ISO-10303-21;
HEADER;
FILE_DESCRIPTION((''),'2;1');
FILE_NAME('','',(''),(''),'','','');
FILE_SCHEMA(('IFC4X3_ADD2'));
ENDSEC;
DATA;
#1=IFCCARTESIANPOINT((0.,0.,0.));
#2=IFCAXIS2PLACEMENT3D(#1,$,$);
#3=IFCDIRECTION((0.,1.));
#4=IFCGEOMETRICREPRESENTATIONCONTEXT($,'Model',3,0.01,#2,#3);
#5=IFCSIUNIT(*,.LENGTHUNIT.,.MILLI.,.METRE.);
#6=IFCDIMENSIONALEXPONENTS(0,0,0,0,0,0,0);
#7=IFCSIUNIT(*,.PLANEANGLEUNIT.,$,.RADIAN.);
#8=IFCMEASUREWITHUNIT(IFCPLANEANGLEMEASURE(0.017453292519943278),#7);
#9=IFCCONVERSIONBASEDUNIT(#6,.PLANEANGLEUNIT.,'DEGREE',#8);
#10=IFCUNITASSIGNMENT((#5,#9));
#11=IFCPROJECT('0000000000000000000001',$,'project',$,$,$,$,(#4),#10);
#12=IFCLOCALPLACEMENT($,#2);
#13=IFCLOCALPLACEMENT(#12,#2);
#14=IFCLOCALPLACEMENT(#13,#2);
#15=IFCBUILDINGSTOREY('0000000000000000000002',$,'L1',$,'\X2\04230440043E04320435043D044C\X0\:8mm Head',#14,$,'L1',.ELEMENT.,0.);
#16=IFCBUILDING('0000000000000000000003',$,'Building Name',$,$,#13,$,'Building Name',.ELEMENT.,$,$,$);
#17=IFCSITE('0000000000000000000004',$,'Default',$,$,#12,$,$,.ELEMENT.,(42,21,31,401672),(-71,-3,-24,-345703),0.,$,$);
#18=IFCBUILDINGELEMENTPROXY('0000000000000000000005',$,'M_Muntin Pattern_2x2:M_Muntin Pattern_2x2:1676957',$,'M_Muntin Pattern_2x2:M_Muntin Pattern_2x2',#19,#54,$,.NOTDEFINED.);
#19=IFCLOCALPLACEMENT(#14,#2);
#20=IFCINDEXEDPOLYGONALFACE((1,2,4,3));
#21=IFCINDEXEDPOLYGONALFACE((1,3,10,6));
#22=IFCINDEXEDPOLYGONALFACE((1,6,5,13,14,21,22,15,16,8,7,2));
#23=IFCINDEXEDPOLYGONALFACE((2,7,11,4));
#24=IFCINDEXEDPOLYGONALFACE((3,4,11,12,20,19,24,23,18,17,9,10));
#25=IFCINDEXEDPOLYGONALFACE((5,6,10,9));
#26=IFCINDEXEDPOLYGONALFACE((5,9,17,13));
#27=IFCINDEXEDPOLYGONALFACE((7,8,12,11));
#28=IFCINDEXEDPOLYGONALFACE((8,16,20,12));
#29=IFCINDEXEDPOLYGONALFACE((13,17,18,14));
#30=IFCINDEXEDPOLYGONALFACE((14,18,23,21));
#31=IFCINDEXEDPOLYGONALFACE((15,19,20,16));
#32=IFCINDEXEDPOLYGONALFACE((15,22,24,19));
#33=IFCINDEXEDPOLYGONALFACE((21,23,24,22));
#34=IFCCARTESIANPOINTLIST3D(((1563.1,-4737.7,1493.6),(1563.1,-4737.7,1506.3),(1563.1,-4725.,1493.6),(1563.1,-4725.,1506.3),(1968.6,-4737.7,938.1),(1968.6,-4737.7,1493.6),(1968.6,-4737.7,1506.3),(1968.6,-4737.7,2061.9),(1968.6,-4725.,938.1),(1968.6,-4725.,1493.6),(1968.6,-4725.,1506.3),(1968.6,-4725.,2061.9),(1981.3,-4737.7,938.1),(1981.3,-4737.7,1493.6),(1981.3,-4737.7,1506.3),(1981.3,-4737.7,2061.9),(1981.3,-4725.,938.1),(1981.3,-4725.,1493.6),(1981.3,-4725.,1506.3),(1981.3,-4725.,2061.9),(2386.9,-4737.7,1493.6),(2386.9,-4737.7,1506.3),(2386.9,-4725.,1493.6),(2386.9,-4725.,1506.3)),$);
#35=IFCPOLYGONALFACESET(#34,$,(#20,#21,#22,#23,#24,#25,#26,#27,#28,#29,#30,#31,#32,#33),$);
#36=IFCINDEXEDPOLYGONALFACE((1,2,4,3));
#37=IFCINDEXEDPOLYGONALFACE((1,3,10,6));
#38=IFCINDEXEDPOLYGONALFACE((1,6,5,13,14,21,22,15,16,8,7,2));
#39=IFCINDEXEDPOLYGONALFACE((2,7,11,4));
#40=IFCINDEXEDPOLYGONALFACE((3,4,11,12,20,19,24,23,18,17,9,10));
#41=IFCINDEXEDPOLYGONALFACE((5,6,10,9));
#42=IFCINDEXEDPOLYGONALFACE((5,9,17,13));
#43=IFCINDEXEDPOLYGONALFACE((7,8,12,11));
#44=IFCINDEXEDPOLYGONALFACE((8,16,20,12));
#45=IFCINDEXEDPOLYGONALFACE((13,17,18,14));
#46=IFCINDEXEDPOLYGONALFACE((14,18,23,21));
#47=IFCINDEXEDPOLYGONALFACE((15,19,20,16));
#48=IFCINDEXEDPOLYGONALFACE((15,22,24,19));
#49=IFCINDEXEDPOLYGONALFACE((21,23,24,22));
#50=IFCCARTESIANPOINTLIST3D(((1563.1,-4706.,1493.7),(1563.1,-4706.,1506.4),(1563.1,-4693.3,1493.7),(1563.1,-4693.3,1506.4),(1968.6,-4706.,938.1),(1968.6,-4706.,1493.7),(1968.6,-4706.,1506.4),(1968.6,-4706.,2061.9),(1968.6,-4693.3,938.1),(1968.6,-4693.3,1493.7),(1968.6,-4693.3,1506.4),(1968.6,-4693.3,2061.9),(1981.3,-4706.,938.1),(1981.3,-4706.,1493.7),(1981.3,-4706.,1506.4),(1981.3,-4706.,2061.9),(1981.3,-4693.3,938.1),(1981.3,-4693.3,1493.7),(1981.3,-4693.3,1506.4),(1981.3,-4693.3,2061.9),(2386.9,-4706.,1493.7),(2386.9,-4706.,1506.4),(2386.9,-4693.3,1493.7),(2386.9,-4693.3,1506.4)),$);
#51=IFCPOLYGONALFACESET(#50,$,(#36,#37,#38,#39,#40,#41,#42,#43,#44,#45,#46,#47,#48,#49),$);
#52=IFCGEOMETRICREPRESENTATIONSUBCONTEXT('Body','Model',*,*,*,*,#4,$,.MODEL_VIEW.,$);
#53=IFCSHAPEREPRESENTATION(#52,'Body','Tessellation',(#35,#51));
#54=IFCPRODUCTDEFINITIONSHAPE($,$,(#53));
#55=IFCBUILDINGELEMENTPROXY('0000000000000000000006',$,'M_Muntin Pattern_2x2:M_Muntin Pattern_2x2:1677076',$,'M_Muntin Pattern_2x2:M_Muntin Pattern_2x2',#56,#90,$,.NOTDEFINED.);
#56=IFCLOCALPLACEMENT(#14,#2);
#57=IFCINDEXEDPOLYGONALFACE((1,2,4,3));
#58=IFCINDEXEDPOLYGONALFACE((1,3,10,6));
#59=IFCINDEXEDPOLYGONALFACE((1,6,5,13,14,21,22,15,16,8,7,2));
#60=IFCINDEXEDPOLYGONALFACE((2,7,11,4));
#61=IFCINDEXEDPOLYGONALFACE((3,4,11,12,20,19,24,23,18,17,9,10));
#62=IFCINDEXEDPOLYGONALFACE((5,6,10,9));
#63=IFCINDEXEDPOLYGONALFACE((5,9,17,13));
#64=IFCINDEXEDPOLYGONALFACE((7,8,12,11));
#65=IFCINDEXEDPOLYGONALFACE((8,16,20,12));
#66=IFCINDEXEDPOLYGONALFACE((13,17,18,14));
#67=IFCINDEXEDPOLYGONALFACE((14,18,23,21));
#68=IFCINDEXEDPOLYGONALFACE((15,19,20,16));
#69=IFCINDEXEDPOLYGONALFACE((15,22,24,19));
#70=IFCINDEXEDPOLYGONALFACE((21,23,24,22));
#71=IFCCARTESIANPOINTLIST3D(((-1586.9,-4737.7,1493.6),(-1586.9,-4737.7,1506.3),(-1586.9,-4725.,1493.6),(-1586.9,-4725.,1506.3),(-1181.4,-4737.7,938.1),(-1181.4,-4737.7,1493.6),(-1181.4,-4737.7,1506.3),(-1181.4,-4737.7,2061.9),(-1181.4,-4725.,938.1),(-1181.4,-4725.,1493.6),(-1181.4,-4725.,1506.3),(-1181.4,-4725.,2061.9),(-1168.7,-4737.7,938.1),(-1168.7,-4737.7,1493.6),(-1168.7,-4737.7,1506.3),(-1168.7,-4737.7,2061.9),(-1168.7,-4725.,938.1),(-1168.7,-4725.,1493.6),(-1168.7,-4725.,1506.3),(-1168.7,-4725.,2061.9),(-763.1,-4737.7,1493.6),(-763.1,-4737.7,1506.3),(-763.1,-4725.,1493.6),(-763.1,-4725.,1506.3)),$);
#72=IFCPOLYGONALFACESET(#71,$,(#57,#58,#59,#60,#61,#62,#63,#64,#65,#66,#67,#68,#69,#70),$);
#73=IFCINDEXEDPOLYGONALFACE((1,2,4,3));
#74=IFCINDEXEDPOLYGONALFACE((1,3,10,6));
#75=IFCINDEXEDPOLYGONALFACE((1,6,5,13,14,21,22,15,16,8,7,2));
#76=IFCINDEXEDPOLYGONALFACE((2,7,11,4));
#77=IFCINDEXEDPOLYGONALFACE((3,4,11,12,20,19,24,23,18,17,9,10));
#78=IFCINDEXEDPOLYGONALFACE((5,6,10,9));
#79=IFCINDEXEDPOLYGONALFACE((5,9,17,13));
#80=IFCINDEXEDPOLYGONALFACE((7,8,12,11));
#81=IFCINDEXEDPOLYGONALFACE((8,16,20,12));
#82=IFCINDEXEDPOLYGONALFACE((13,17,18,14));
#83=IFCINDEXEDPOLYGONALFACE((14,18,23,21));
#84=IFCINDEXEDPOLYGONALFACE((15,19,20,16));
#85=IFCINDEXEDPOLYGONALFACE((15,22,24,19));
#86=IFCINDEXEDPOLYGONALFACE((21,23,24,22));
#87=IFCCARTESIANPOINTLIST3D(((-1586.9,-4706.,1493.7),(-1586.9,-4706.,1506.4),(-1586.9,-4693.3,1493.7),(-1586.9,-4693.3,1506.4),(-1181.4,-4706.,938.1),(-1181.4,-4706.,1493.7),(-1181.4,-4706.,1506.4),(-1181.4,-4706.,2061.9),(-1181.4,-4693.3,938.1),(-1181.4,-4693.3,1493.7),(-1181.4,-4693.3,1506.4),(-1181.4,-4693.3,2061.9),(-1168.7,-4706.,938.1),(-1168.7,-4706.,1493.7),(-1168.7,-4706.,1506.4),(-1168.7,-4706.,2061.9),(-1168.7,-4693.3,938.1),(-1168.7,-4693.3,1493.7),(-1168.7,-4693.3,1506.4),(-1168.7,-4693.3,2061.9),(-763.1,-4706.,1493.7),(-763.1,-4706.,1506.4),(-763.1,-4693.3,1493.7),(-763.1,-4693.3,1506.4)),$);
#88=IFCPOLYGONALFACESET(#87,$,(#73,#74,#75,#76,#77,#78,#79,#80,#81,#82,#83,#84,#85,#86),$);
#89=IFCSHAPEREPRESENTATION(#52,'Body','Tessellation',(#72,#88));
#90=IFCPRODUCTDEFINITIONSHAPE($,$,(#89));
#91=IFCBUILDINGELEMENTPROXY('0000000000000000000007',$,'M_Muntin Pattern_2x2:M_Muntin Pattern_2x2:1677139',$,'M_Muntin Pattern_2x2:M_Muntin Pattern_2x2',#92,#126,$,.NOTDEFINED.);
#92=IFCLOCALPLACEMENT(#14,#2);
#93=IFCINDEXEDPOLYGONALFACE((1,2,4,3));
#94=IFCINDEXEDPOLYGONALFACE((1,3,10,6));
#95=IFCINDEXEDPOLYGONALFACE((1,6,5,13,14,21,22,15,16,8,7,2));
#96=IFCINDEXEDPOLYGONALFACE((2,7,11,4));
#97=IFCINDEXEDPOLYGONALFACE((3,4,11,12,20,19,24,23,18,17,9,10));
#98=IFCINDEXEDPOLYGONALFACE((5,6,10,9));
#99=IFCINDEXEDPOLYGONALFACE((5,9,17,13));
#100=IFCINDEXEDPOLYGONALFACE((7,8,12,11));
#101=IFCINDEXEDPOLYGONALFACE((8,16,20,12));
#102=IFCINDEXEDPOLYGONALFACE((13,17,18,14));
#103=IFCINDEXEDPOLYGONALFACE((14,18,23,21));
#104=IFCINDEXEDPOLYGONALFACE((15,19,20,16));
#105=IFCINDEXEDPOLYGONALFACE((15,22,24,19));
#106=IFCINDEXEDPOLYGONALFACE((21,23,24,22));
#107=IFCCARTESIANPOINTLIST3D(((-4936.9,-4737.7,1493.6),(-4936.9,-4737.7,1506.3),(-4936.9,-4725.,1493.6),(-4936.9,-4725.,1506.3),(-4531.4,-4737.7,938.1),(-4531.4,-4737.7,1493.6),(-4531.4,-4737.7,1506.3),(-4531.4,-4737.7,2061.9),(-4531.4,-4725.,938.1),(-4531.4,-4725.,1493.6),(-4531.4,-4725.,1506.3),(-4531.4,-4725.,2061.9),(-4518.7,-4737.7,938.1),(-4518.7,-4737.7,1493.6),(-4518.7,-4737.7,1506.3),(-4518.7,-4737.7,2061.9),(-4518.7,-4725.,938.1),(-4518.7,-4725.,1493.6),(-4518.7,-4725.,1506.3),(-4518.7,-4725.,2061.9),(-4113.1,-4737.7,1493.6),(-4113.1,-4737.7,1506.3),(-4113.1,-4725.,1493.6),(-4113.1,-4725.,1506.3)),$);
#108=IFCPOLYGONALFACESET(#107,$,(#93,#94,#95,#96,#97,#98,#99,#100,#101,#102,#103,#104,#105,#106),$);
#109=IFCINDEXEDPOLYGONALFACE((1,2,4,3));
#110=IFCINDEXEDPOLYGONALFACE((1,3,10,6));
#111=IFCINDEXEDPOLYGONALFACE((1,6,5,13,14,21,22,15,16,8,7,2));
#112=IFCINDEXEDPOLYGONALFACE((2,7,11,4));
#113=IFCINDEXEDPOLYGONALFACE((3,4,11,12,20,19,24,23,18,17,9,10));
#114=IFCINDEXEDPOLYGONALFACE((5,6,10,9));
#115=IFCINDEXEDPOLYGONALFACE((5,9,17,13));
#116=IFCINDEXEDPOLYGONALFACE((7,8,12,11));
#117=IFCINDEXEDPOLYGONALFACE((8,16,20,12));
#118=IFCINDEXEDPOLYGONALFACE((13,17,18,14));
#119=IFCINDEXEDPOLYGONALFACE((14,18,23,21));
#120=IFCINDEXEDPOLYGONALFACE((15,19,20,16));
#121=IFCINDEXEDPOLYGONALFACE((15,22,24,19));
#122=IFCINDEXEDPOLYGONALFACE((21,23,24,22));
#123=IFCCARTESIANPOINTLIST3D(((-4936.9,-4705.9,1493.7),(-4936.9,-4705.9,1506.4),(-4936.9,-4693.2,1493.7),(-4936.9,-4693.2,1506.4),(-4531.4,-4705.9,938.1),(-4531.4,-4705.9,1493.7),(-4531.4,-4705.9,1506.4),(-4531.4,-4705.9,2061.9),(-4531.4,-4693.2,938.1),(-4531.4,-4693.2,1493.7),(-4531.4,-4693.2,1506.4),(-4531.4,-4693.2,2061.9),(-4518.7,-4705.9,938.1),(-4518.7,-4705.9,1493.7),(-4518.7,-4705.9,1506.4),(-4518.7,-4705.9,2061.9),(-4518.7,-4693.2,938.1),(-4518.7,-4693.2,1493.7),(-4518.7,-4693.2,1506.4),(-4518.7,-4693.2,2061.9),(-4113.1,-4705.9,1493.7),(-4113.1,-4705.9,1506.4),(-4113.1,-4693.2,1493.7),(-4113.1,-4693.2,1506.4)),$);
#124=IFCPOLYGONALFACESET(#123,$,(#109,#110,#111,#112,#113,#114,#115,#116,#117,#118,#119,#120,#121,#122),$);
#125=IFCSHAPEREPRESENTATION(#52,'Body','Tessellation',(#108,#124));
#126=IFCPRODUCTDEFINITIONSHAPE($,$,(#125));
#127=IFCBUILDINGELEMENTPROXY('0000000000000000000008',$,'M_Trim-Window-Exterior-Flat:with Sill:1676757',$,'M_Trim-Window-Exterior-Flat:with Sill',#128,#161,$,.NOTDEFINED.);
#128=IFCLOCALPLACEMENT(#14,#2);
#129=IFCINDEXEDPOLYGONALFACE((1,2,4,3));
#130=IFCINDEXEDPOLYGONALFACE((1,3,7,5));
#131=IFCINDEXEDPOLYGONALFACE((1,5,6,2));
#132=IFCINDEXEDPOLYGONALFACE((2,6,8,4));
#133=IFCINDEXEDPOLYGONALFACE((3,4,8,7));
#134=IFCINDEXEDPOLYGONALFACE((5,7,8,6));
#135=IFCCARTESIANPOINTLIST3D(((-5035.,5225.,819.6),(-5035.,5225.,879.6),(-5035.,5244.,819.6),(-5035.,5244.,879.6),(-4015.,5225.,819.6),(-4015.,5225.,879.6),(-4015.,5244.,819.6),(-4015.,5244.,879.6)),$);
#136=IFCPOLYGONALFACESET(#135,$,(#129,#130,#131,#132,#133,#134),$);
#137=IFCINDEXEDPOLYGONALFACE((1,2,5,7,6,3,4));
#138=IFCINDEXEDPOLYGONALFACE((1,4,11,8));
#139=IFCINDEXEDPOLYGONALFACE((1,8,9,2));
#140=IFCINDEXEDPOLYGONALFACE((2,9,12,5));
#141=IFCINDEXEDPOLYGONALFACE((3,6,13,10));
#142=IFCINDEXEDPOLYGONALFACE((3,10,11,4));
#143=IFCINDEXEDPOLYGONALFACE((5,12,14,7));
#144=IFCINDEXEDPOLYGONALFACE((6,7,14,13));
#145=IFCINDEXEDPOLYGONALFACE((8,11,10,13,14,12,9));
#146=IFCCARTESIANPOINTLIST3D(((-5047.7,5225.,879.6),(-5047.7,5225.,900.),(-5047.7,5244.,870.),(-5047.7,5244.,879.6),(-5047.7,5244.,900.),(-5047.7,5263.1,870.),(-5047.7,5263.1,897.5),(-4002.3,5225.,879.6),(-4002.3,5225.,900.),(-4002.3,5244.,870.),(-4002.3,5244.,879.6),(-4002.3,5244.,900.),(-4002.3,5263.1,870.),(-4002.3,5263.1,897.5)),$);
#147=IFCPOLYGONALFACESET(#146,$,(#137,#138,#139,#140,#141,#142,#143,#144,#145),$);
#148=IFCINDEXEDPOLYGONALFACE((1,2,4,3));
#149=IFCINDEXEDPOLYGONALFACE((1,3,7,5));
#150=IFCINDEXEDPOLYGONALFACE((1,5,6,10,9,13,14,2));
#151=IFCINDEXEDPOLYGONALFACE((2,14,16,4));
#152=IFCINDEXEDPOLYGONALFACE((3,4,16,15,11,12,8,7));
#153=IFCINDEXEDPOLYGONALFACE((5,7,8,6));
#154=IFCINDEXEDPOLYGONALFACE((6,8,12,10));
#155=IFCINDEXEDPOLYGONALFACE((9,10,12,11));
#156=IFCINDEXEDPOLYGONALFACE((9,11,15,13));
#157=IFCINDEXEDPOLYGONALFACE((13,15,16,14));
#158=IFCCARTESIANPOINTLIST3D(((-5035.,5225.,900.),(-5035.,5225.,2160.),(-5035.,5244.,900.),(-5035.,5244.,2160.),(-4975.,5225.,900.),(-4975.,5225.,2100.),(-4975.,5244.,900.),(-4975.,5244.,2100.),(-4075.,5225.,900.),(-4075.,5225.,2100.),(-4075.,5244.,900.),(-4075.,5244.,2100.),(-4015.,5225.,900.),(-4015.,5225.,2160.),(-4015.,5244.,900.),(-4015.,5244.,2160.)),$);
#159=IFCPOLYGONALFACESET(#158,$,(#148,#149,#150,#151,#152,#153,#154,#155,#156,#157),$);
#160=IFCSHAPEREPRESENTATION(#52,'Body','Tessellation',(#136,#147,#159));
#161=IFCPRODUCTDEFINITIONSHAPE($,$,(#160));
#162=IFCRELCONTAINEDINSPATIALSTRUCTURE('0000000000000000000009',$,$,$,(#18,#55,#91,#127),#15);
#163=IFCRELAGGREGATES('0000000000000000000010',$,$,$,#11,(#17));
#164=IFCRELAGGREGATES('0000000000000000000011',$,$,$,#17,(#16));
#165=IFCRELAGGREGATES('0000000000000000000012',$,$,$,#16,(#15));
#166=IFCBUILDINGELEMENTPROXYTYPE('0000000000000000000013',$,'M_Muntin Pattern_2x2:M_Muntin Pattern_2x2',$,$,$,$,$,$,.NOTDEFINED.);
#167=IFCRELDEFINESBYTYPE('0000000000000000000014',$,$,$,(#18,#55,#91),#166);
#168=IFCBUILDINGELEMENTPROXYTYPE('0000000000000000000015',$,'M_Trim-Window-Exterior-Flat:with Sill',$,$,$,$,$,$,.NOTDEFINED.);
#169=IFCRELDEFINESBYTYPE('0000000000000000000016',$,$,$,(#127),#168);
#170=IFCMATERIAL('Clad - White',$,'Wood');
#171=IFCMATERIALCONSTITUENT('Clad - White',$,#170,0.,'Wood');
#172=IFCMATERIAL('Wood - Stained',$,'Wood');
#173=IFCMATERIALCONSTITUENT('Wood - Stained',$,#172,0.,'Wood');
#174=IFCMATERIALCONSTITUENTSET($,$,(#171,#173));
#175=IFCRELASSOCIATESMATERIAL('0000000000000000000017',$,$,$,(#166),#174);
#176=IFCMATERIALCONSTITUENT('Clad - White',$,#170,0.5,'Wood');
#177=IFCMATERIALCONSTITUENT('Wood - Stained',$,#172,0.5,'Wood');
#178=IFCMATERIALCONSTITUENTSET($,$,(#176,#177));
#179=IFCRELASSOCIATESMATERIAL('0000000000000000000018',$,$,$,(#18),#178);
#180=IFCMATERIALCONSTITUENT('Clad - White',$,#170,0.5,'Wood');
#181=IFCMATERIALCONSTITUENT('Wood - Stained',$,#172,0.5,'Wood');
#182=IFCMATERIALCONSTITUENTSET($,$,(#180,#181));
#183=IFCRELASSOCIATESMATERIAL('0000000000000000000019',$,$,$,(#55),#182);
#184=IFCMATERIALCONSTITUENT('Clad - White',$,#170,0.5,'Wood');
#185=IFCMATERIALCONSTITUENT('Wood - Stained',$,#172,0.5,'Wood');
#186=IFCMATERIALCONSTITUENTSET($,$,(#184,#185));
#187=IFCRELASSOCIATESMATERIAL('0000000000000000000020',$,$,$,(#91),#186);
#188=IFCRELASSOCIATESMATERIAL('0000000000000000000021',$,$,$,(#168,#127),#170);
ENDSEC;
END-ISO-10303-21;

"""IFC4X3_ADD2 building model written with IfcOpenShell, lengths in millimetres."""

from ifc_helpers import new_model, entity, si_unit, converted_unit, direction, frame, frame_2d, origin, place, context, subcontext, project, spatial, polyline, rectangle, outline, extrude, source, transform, mapped, material, constituent, constituent_set, type_object, type_shapes, element, save


model = new_model("IFC4X3_ADD2")

# Units and contexts
model_context = context("Model", 3, precision=0.01, world=origin(), true_north=direction((0.0, 1.0)))
body_context = subcontext(model_context, "Body", "Model", "MODEL_VIEW")
ifc_project = project(units=[si_unit("LENGTHUNIT", "METRE", prefix="MILLI"), converted_unit("PLANEANGLEUNIT", "DEGREE", entity("IfcPlaneAngleMeasure", 0.017453292519943278), si_unit("PLANEANGLEUNIT", "RADIAN"), dimensions=[0, 0, 0, 0, 0, 0, 0])], contexts=[model_context])

# Site, building, storey
site_placement = place(None, origin())
site = spatial("IfcSite", under=ifc_project, at=site_placement, Name="Default", CompositionType="ELEMENT", RefLatitude=(42, 21, 31, 401672), RefLongitude=(-71, -3, -24, -345703), RefElevation=0.0)
building_placement = place(site_placement, origin())
building = spatial("IfcBuilding", under=site, at=building_placement, Name="Building Name", LongName="Building Name", CompositionType="ELEMENT")
storey_placement = place(building_placement, origin())
storey = spatial("IfcBuildingStorey", under=building, at=storey_placement, Name="L1", ObjectType="Уровень:8mm Head", LongName="L1", CompositionType="ELEMENT", Elevation=0.0)

# Building element proxies
ifc_material_1 = material(Name="Clad - White", Category="Wood")
ifc_material_2 = material(Name="Wood - Stained", Category="Wood")
ifc_constituent_1 = constituent(ifc_material_1, Name="Clad - White", Category="Wood", fraction=0.0)
ifc_constituent_2 = constituent(ifc_material_2, Name="Wood - Stained", Category="Wood", fraction=0.0)
ifc_constituent_set_1 = constituent_set(constituents=[ifc_constituent_1, ifc_constituent_2])
building_element_proxy_type_1 = type_object("IfcBuildingElementProxyType", Name="M_Muntin Pattern_2x2:M_Muntin Pattern_2x2", PredefinedType="NOTDEFINED", material=ifc_constituent_set_1)
shared_shape_1 = source(origin(), body_context, "Body", "SweptSolid", [
    extrude(outline(polyline([(6.4, -6.4), (561.9, -6.4), (561.9, 6.3), (6.4, 6.3), (6.4, 411.9), (-6.3, 411.9), (-6.3, 6.3), (-561.9, 6.3), (-561.9, -6.4), (-6.3, -6.4), (-6.3, -411.9), (6.4, -411.9), (6.4, -6.4)])), frame((0.0, -22.2, 561.9), z_axis=(0.0, 1.0, 0.0), x_axis=(0.0, 0.0, 1.0)), (0.0, 0.0, 1.0), 12.7),
    extrude(outline(polyline([(6.4, -6.4), (561.9, -6.4), (561.9, 6.3), (6.4, 6.3), (6.4, 411.9), (-6.3, 411.9), (-6.3, 6.3), (-561.9, 6.3), (-561.9, -6.4), (-6.3, -6.4), (-6.3, -411.9), (6.4, -411.9), (6.4, -6.4)])), frame((0.0, 9.5, 561.9), z_axis=(0.0, 1.0, 0.0), x_axis=(0.0, 0.0, 1.0)), (0.0, 0.0, 1.0), 12.7),
])
type_shapes(building_element_proxy_type_1, [shared_shape_1])
ifc_constituent_3 = constituent(ifc_material_1, Name="Clad - White", Category="Wood", fraction=0.5)
ifc_constituent_4 = constituent(ifc_material_2, Name="Wood - Stained", Category="Wood", fraction=0.5)
ifc_constituent_set_2 = constituent_set(constituents=[ifc_constituent_3, ifc_constituent_4])
proxy_1_placement = place(storey_placement, frame((1975.0, -4715.5, 938.1)))
element("IfcBuildingElementProxy", 1, at=proxy_1_placement, inside=storey, type_object=building_element_proxy_type_1, material=ifc_constituent_set_2, Name="M_Muntin Pattern_2x2:M_Muntin Pattern_2x2:1676957", ObjectType="M_Muntin Pattern_2x2:M_Muntin Pattern_2x2", PredefinedType="NOTDEFINED", context=body_context, shape_type="MappedRepresentation", body=[
    mapped(shared_shape_1, transform((0.0, 0.0, 0.0), scale=1.0)),
])
ifc_constituent_5 = constituent(ifc_material_1, Name="Clad - White", Category="Wood", fraction=0.5)
ifc_constituent_6 = constituent(ifc_material_2, Name="Wood - Stained", Category="Wood", fraction=0.5)
ifc_constituent_set_3 = constituent_set(constituents=[ifc_constituent_5, ifc_constituent_6])
proxy_2_placement = place(storey_placement, frame((-1175.0, -4715.5, 938.1)))
element("IfcBuildingElementProxy", 2, at=proxy_2_placement, inside=storey, type_object=building_element_proxy_type_1, material=ifc_constituent_set_3, Name="M_Muntin Pattern_2x2:M_Muntin Pattern_2x2:1677076", ObjectType="M_Muntin Pattern_2x2:M_Muntin Pattern_2x2", PredefinedType="NOTDEFINED", context=body_context, shape_type="MappedRepresentation", body=[
    mapped(shared_shape_1, transform((0.0, 0.0, 0.0), scale=1.0)),
])
ifc_constituent_7 = constituent(ifc_material_1, Name="Clad - White", Category="Wood", fraction=0.5)
ifc_constituent_8 = constituent(ifc_material_2, Name="Wood - Stained", Category="Wood", fraction=0.5)
ifc_constituent_set_4 = constituent_set(constituents=[ifc_constituent_7, ifc_constituent_8])
proxy_3_placement = place(storey_placement, frame((-4525.0, -4715.5, 938.1)))
element("IfcBuildingElementProxy", 3, at=proxy_3_placement, inside=storey, type_object=building_element_proxy_type_1, material=ifc_constituent_set_4, Name="M_Muntin Pattern_2x2:M_Muntin Pattern_2x2:1677139", ObjectType="M_Muntin Pattern_2x2:M_Muntin Pattern_2x2", PredefinedType="NOTDEFINED", context=body_context, shape_type="MappedRepresentation", body=[
    mapped(shared_shape_1, transform((0.0, 0.0, 0.0), scale=1.0)),
])
building_element_proxy_type_2 = type_object("IfcBuildingElementProxyType", Name="M_Trim-Window-Exterior-Flat:with Sill", PredefinedType="NOTDEFINED", material=ifc_material_1)
shared_shape_2 = source(origin(), body_context, "Body", "SweptSolid", [
    extrude(rectangle(XDim=1020.0, YDim=60.0, at=frame_2d((0.0, 0.0), x_axis=(1.0, 0.0))), frame((0.0, -1250.4, 0.0), z_axis=(0.0, 0.0, 1.0), x_axis=(-1.0, 0.0, 0.0)), (0.0, 0.0, 1.0), 19.0),
    extrude(outline(polyline([(-19.0, -15.2), (0.0, -15.2), (0.0, -5.7), (19.0, -5.7), (19.0, 14.8), (0.0, 14.8), (-19.0, 12.3), (-19.0, -15.2)])), frame((-522.7, -1214.8, 19.0), z_axis=(1.0, 0.0, 0.0), x_axis=(0.0, 0.0, -1.0)), (0.0, 0.0, 1.0), 1045.4),
    extrude(outline(polyline([(-645.0, -510.0), (615.0, -510.0), (615.0, -450.0), (-585.0, -450.0), (-585.0, 450.0), (615.0, 450.0), (615.0, 510.0), (-645.0, 510.0), (-645.0, -510.0)])), frame((0.0, -585.0, 0.0), z_axis=(0.0, 0.0, 1.0), x_axis=(0.0, -1.0, 0.0)), (0.0, 0.0, 1.0), 19.0),
])
type_shapes(building_element_proxy_type_2, [shared_shape_2])
for number, where, z_axis, x_axis, name in (
    (4, (-4525.0, 5225.0, 2100.0), (0.0, 1.0, 0.0), (-1.0, 0.0, 0.0), "M_Trim-Window-Exterior-Flat:with Sill:1676757"),
):
    element("IfcBuildingElementProxy", number, at=place(storey_placement, frame(where, z_axis=z_axis, x_axis=x_axis)), inside=storey, type_object=building_element_proxy_type_2, material=ifc_material_1, Name=name, ObjectType="M_Trim-Window-Exterior-Flat:with Sill", PredefinedType="NOTDEFINED", context=body_context, shape_type="MappedRepresentation", body=[
        mapped(shared_shape_2, transform((0.0, 0.0, 0.0), scale=1.0)),
    ])

save(model, "model.ifc")
